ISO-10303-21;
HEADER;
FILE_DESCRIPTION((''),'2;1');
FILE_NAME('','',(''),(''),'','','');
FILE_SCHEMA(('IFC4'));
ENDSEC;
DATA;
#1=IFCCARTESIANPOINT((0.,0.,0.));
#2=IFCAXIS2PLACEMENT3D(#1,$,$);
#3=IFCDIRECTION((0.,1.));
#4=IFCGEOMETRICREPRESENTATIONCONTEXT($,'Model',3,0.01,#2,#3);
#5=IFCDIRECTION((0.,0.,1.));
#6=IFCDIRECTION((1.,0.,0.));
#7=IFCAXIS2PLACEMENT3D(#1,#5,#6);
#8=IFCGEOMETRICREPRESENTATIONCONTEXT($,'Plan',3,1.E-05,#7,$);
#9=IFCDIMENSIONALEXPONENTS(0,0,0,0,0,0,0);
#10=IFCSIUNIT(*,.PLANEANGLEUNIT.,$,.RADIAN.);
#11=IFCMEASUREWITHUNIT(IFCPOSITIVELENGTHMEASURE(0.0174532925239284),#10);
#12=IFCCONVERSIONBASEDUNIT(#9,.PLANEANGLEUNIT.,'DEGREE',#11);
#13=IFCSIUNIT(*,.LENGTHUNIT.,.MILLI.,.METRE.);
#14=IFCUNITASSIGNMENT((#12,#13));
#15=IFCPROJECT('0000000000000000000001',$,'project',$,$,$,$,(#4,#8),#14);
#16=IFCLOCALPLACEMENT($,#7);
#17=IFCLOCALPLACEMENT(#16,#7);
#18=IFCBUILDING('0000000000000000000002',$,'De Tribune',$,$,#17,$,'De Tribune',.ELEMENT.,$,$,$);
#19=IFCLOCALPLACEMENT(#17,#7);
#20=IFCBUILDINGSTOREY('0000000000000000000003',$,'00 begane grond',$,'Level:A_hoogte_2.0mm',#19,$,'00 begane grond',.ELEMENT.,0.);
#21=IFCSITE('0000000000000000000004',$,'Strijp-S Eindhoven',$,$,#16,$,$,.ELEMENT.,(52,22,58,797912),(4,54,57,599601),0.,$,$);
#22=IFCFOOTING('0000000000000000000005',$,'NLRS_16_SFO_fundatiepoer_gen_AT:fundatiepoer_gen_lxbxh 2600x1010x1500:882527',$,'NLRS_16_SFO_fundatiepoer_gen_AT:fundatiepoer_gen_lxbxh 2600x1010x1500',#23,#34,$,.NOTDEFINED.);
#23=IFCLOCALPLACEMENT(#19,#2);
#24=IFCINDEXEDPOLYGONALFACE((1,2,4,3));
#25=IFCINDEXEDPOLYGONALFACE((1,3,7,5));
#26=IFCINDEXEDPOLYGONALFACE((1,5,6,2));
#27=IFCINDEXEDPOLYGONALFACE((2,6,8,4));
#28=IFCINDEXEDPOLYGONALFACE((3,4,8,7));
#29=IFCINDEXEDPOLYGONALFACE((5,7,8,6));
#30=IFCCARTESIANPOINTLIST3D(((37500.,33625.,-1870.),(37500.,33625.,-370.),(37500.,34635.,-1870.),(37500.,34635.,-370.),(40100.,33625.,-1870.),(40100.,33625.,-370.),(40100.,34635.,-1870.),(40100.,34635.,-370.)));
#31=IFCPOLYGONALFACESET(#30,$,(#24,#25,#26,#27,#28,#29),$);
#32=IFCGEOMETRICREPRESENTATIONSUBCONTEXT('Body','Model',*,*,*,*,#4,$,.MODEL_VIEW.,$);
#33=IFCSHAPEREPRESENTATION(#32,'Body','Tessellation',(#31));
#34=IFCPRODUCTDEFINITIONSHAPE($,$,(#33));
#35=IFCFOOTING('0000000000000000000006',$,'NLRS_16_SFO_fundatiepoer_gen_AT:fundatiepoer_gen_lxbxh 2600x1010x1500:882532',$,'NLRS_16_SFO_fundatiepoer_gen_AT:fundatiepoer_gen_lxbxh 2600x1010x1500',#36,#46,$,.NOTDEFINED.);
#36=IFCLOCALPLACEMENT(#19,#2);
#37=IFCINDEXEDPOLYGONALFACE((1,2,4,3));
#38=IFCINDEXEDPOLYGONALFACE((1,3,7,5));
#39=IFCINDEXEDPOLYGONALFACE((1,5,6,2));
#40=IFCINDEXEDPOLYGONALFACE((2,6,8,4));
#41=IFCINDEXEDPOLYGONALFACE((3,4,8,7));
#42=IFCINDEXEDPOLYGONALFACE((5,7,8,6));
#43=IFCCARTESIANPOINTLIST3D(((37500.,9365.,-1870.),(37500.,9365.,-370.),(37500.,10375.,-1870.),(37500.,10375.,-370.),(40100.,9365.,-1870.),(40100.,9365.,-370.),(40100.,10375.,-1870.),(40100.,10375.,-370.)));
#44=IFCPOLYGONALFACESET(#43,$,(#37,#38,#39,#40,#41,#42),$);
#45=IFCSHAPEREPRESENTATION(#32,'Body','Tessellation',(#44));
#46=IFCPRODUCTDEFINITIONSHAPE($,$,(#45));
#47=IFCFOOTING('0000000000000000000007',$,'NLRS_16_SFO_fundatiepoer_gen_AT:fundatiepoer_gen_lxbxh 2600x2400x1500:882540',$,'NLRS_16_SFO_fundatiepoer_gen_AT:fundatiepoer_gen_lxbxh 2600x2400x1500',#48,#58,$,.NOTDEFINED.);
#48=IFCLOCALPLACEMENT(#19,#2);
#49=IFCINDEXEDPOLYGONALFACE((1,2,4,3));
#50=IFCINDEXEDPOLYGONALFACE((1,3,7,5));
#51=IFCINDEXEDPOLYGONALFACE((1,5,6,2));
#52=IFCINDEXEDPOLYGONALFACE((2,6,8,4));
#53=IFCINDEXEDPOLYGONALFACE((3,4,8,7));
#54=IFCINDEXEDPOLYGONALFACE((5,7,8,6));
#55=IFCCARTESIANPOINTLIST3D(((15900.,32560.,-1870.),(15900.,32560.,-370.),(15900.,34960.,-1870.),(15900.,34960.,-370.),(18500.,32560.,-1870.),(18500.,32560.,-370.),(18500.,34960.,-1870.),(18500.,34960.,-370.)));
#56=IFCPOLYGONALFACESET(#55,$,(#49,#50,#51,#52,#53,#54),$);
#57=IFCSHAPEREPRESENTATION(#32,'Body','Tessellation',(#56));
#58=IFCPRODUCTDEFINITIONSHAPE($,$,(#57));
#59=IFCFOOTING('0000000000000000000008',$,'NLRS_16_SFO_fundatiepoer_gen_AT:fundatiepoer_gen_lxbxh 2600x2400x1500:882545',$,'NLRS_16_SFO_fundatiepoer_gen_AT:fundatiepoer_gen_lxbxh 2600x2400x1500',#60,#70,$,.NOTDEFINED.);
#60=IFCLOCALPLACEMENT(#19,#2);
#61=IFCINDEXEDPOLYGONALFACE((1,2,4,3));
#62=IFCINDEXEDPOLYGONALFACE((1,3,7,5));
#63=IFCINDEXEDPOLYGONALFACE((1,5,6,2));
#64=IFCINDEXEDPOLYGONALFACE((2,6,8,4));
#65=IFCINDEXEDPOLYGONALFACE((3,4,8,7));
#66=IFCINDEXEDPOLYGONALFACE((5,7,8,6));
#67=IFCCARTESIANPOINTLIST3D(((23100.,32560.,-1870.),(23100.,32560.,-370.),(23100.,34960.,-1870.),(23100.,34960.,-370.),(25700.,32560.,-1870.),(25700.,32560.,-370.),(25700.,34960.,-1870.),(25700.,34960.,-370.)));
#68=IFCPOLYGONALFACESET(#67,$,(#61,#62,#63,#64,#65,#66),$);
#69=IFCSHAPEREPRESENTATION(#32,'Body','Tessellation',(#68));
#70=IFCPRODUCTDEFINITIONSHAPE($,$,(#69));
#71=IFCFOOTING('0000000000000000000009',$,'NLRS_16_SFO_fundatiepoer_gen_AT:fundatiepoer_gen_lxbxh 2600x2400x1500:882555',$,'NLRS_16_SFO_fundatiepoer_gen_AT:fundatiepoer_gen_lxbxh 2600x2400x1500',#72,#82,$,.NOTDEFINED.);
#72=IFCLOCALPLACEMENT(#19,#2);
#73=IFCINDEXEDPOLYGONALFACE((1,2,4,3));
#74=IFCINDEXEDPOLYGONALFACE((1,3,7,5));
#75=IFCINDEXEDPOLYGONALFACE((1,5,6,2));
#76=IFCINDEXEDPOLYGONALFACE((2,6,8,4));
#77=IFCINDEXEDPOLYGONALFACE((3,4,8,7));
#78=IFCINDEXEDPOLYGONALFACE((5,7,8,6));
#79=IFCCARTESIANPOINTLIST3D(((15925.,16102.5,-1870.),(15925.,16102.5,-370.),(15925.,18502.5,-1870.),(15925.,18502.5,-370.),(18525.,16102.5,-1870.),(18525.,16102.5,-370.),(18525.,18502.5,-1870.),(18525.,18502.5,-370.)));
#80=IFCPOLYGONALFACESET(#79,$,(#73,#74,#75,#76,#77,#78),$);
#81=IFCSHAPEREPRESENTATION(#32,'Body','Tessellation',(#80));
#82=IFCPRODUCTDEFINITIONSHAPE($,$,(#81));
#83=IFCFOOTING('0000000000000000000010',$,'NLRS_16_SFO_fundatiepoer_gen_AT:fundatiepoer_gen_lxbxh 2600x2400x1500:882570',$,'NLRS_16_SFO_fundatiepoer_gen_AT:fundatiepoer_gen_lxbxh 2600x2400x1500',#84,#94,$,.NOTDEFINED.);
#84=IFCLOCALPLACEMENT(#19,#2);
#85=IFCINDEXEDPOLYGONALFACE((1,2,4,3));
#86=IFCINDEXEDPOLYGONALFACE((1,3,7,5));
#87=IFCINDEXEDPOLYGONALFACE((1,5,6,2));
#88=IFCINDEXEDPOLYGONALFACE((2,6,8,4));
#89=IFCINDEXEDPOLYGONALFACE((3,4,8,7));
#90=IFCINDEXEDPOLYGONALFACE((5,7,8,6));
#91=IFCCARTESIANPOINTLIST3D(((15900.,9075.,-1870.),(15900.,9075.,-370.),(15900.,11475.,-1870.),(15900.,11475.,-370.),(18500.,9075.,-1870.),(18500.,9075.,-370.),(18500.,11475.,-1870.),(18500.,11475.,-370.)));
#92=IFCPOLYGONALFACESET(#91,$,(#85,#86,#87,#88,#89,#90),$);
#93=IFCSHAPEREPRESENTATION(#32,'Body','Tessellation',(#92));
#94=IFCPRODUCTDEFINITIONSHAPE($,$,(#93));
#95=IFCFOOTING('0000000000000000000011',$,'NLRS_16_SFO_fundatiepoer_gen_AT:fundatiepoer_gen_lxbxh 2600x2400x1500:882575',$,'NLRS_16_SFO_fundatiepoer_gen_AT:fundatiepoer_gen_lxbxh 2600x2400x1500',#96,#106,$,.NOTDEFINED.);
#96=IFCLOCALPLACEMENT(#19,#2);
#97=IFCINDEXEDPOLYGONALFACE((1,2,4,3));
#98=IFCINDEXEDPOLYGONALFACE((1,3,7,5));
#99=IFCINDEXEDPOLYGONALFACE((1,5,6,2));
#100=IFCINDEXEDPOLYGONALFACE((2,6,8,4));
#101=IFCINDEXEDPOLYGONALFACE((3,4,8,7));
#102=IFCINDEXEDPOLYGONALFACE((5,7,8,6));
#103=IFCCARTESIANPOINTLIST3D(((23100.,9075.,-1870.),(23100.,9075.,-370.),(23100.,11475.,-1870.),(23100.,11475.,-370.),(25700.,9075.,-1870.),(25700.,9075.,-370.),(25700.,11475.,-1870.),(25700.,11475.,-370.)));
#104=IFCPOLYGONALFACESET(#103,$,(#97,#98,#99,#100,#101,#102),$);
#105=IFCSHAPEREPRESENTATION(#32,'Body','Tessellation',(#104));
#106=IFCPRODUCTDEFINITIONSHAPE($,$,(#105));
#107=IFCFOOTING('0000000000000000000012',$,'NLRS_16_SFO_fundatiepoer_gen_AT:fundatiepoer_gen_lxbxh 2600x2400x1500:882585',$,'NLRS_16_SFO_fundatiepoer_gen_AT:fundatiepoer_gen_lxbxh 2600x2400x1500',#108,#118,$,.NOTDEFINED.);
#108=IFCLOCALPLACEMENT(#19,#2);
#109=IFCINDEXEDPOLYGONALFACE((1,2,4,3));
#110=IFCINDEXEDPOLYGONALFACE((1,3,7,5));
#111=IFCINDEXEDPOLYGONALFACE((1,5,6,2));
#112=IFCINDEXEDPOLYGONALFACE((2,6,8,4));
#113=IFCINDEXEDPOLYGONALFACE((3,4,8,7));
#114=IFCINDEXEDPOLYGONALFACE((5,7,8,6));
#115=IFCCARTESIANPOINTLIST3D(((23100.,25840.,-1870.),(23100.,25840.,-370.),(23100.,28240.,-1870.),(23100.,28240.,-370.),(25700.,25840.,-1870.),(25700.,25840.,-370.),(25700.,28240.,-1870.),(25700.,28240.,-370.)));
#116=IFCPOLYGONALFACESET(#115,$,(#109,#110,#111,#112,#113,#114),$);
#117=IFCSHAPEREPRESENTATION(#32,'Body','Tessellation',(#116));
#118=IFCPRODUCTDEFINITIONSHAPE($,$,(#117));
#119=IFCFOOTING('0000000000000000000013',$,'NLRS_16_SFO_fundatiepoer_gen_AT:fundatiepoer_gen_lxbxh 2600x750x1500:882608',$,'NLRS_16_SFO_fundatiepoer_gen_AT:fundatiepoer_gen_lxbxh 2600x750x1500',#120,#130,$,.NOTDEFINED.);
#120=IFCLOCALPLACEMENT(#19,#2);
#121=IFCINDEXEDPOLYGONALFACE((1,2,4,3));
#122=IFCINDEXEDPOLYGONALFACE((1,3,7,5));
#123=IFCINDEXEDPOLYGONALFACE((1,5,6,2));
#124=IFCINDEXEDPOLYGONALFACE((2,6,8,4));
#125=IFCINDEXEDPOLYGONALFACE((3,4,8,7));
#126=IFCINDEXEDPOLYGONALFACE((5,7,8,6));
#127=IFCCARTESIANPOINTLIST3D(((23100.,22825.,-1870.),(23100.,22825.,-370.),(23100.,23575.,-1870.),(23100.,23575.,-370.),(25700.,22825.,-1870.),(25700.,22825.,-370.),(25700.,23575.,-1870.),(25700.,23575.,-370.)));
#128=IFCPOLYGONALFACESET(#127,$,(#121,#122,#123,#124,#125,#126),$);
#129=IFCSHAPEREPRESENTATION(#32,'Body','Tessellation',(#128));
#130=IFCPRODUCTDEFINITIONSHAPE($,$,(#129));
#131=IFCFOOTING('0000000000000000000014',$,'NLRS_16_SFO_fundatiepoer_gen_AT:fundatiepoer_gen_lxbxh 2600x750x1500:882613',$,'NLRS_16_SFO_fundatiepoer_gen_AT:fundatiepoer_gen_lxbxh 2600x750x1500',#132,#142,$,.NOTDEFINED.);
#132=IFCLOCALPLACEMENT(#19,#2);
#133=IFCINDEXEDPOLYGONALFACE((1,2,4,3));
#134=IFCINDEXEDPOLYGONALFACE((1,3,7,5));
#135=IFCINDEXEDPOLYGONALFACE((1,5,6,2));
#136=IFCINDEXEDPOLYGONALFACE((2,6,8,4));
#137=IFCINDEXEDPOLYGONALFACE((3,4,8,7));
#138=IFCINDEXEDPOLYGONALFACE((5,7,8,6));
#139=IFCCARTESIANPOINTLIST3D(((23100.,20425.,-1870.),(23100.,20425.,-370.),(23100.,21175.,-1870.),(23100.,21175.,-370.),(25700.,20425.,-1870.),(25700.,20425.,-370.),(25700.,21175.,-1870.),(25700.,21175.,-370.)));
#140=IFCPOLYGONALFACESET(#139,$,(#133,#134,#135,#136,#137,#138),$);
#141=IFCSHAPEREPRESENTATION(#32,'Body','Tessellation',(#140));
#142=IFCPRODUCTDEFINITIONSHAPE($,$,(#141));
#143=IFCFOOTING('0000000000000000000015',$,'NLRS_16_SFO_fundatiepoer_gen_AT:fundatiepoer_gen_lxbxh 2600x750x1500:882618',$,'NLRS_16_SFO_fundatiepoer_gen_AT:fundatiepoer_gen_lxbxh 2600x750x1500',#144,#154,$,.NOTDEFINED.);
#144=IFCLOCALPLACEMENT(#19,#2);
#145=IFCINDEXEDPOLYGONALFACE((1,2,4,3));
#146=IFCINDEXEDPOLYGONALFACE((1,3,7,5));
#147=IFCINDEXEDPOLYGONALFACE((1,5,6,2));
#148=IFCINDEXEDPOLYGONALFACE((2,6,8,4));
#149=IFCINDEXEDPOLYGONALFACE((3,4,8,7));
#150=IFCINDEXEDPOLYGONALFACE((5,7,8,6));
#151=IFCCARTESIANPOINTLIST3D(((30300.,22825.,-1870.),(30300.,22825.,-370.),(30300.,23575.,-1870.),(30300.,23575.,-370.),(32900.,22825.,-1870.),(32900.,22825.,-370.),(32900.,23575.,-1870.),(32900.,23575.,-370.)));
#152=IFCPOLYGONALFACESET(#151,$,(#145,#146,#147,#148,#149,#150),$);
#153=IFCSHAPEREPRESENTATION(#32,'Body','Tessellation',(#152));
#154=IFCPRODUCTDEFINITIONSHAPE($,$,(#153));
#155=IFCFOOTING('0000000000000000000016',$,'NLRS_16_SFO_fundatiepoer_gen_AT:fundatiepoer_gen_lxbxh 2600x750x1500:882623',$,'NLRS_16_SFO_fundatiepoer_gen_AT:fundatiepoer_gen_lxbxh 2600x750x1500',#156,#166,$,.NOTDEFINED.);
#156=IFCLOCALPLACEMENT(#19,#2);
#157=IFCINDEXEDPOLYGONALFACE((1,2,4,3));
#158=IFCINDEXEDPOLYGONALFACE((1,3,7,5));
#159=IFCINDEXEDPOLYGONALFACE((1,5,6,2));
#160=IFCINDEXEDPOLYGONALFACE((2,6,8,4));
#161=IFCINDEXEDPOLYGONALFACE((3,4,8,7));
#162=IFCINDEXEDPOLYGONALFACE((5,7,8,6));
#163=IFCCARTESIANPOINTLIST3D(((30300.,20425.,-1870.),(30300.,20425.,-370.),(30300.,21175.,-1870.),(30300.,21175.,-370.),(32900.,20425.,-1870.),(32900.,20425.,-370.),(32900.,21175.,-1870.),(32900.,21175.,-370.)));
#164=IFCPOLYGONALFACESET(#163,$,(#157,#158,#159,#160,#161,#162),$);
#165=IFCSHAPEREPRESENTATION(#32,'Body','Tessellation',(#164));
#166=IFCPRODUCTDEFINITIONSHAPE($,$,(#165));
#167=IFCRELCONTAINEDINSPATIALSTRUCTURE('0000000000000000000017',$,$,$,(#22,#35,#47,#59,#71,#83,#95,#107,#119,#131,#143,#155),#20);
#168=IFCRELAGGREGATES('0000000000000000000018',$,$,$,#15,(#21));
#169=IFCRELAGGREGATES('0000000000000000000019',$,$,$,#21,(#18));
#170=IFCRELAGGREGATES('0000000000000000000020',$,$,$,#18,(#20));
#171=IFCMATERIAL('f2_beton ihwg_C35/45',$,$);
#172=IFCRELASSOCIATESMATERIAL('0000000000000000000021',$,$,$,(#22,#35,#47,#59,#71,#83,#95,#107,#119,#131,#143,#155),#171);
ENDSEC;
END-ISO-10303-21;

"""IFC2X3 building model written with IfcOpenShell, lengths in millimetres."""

from ifc_helpers import new_model, entity, si_unit, converted_unit, direction, frame, frame_2d, origin, origin_with_axes, place, context, subcontext, project, spatial, rectangle, extrude, source, transform, mapped, material, element, save


model = new_model("IFC2X3")

# Units and contexts
model_context = context("Model", 3, precision=0.01, world=origin(), true_north=direction((0.0, 1.0)))
plan_context = context("Plan", 3, precision=1e-05, world=origin_with_axes())
body_context = subcontext(model_context, "Body", "Model", "MODEL_VIEW")
ifc_project = project(units=[converted_unit("PLANEANGLEUNIT", "DEGREE", entity("IfcPositiveLengthMeasure", 0.0174532925239284), si_unit("PLANEANGLEUNIT", "RADIAN"), dimensions=[0, 0, 0, 0, 0, 0, 0]), si_unit("LENGTHUNIT", "METRE", prefix="MILLI")], contexts=[model_context, plan_context])

# Site, building, storey
site_placement = place(None, origin_with_axes())
site = spatial("IfcSite", under=ifc_project, at=site_placement, Name="Strijp-S Eindhoven", CompositionType="ELEMENT", RefLatitude=(52, 22, 58, 797912), RefLongitude=(4, 54, 57, 599601), RefElevation=0.0)
building_placement = place(site_placement, origin_with_axes())
building = spatial("IfcBuilding", under=site, at=building_placement, Name="De Tribune", LongName="De Tribune", CompositionType="ELEMENT")
storey_placement = place(building_placement, origin_with_axes())
storey = spatial("IfcBuildingStorey", under=building, at=storey_placement, Name="00 begane grond", ObjectType="Level:A_hoogte_2.0mm", LongName="00 begane grond", CompositionType="ELEMENT", Elevation=0.0)

# Footings
ifc_material_1 = material(Name="f2_beton ihwg_C35/45")
shared_shape_1 = source(origin(), body_context, "Body", "SweptSolid", [
    extrude(rectangle(XDim=1010.0, YDim=2600.0, at=frame_2d((0.0, 0.0), x_axis=(1.0, 0.0))), frame((38800.0, 34130.0, -1870.0), z_axis=(0.0, 0.0, 1.0), x_axis=(0.0, 1.0, 0.0)), (0.0, 0.0, 1.0), 1500.0),
])
footing_1_placement = place(storey_placement, origin_with_axes())
element("IfcFooting", 1, at=footing_1_placement, inside=storey, material=ifc_material_1, Name="NLRS_16_SFO_fundatiepoer_gen_AT:fundatiepoer_gen_lxbxh 2600x1010x1500:882527", ObjectType="NLRS_16_SFO_fundatiepoer_gen_AT:fundatiepoer_gen_lxbxh 2600x1010x1500", PredefinedType="NOTDEFINED", context=body_context, shape_type="MappedRepresentation", body=[
    mapped(shared_shape_1, transform((0.0, 0.0, 0.0), scale=1.0)),
])
shared_shape_2 = source(origin(), body_context, "Body", "SweptSolid", [
    extrude(rectangle(XDim=1010.0, YDim=2600.0, at=frame_2d((0.0, 0.0), x_axis=(1.0, 0.0))), frame((38800.0, 9870.0, -1870.0), z_axis=(0.0, 0.0, 1.0), x_axis=(0.0, -1.0, 0.0)), (0.0, 0.0, 1.0), 1500.0),
])
footing_2_placement = place(storey_placement, origin_with_axes())
element("IfcFooting", 2, at=footing_2_placement, inside=storey, material=ifc_material_1, Name="NLRS_16_SFO_fundatiepoer_gen_AT:fundatiepoer_gen_lxbxh 2600x1010x1500:882532", ObjectType="NLRS_16_SFO_fundatiepoer_gen_AT:fundatiepoer_gen_lxbxh 2600x1010x1500", PredefinedType="NOTDEFINED", context=body_context, shape_type="MappedRepresentation", body=[
    mapped(shared_shape_2, transform((0.0, 0.0, 0.0), scale=1.0)),
])
shared_shape_3 = source(origin(), body_context, "Body", "SweptSolid", [
    extrude(rectangle(XDim=2400.0, YDim=2600.0, at=frame_2d((0.0, 0.0), x_axis=(1.0, 0.0))), frame((17200.0, 33760.0, -1870.0), z_axis=(0.0, 0.0, 1.0), x_axis=(0.0, -1.0, 0.0)), (0.0, 0.0, 1.0), 1500.0),
])
footing_3_placement = place(storey_placement, origin_with_axes())
element("IfcFooting", 3, at=footing_3_placement, inside=storey, material=ifc_material_1, Name="NLRS_16_SFO_fundatiepoer_gen_AT:fundatiepoer_gen_lxbxh 2600x2400x1500:882540", ObjectType="NLRS_16_SFO_fundatiepoer_gen_AT:fundatiepoer_gen_lxbxh 2600x2400x1500", PredefinedType="NOTDEFINED", context=body_context, shape_type="MappedRepresentation", body=[
    mapped(shared_shape_3, transform((0.0, 0.0, 0.0), scale=1.0)),
])
shared_shape_4 = source(origin(), body_context, "Body", "SweptSolid", [
    extrude(rectangle(XDim=2400.0, YDim=2600.0, at=frame_2d((0.0, 0.0), x_axis=(1.0, 0.0))), frame((24400.0, 33760.0, -1870.0), z_axis=(0.0, 0.0, 1.0), x_axis=(0.0, -1.0, 0.0)), (0.0, 0.0, 1.0), 1500.0),
])
footing_4_placement = place(storey_placement, origin_with_axes())
element("IfcFooting", 4, at=footing_4_placement, inside=storey, material=ifc_material_1, Name="NLRS_16_SFO_fundatiepoer_gen_AT:fundatiepoer_gen_lxbxh 2600x2400x1500:882545", ObjectType="NLRS_16_SFO_fundatiepoer_gen_AT:fundatiepoer_gen_lxbxh 2600x2400x1500", PredefinedType="NOTDEFINED", context=body_context, shape_type="MappedRepresentation", body=[
    mapped(shared_shape_4, transform((0.0, 0.0, 0.0), scale=1.0)),
])
shared_shape_5 = source(origin(), body_context, "Body", "SweptSolid", [
    extrude(rectangle(XDim=2400.0, YDim=2600.0, at=frame_2d((0.0, 0.0), x_axis=(1.0, 0.0))), frame((17225.0, 17302.5, -1870.0), z_axis=(0.0, 0.0, 1.0), x_axis=(0.0, -1.0, 0.0)), (0.0, 0.0, 1.0), 1500.0),
])
footing_5_placement = place(storey_placement, origin_with_axes())
element("IfcFooting", 5, at=footing_5_placement, inside=storey, material=ifc_material_1, Name="NLRS_16_SFO_fundatiepoer_gen_AT:fundatiepoer_gen_lxbxh 2600x2400x1500:882555", ObjectType="NLRS_16_SFO_fundatiepoer_gen_AT:fundatiepoer_gen_lxbxh 2600x2400x1500", PredefinedType="NOTDEFINED", context=body_context, shape_type="MappedRepresentation", body=[
    mapped(shared_shape_5, transform((0.0, 0.0, 0.0), scale=1.0)),
])
shared_shape_6 = source(origin(), body_context, "Body", "SweptSolid", [
    extrude(rectangle(XDim=2600.0, YDim=2400.0, at=frame_2d((0.0, 0.0), x_axis=(1.0, 0.0))), frame((17200.0, 10275.0, -1870.0)), (0.0, 0.0, 1.0), 1500.0),
])
footing_6_placement = place(storey_placement, origin_with_axes())
element("IfcFooting", 6, at=footing_6_placement, inside=storey, material=ifc_material_1, Name="NLRS_16_SFO_fundatiepoer_gen_AT:fundatiepoer_gen_lxbxh 2600x2400x1500:882570", ObjectType="NLRS_16_SFO_fundatiepoer_gen_AT:fundatiepoer_gen_lxbxh 2600x2400x1500", PredefinedType="NOTDEFINED", context=body_context, shape_type="MappedRepresentation", body=[
    mapped(shared_shape_6, transform((0.0, 0.0, 0.0), scale=1.0)),
])
shared_shape_7 = source(origin(), body_context, "Body", "SweptSolid", [
    extrude(rectangle(XDim=2600.0, YDim=2400.0, at=frame_2d((0.0, 0.0), x_axis=(1.0, 0.0))), frame((24400.0, 10275.0, -1870.0)), (0.0, 0.0, 1.0), 1500.0),
])
footing_7_placement = place(storey_placement, origin_with_axes())
element("IfcFooting", 7, at=footing_7_placement, inside=storey, material=ifc_material_1, Name="NLRS_16_SFO_fundatiepoer_gen_AT:fundatiepoer_gen_lxbxh 2600x2400x1500:882575", ObjectType="NLRS_16_SFO_fundatiepoer_gen_AT:fundatiepoer_gen_lxbxh 2600x2400x1500", PredefinedType="NOTDEFINED", context=body_context, shape_type="MappedRepresentation", body=[
    mapped(shared_shape_7, transform((0.0, 0.0, 0.0), scale=1.0)),
])
shared_shape_8 = source(origin(), body_context, "Body", "SweptSolid", [
    extrude(rectangle(XDim=2600.0, YDim=2400.0, at=frame_2d((0.0, 0.0), x_axis=(1.0, 0.0))), frame((24400.0, 27040.0, -1870.0)), (0.0, 0.0, 1.0), 1500.0),
])
footing_8_placement = place(storey_placement, origin_with_axes())
element("IfcFooting", 8, at=footing_8_placement, inside=storey, material=ifc_material_1, Name="NLRS_16_SFO_fundatiepoer_gen_AT:fundatiepoer_gen_lxbxh 2600x2400x1500:882585", ObjectType="NLRS_16_SFO_fundatiepoer_gen_AT:fundatiepoer_gen_lxbxh 2600x2400x1500", PredefinedType="NOTDEFINED", context=body_context, shape_type="MappedRepresentation", body=[
    mapped(shared_shape_8, transform((0.0, 0.0, 0.0), scale=1.0)),
])
shared_shape_9 = source(origin(), body_context, "Body", "SweptSolid", [
    extrude(rectangle(XDim=750.0, YDim=2600.0, at=frame_2d((0.0, 0.0), x_axis=(1.0, 0.0))), frame((24400.0, 23200.0, -1870.0), z_axis=(0.0, 0.0, 1.0), x_axis=(0.0, -1.0, 0.0)), (0.0, 0.0, 1.0), 1500.0),
])
footing_9_placement = place(storey_placement, origin_with_axes())
element("IfcFooting", 9, at=footing_9_placement, inside=storey, material=ifc_material_1, Name="NLRS_16_SFO_fundatiepoer_gen_AT:fundatiepoer_gen_lxbxh 2600x750x1500:882608", ObjectType="NLRS_16_SFO_fundatiepoer_gen_AT:fundatiepoer_gen_lxbxh 2600x750x1500", PredefinedType="NOTDEFINED", context=body_context, shape_type="MappedRepresentation", body=[
    mapped(shared_shape_9, transform((0.0, 0.0, 0.0), scale=1.0)),
])
shared_shape_10 = source(origin(), body_context, "Body", "SweptSolid", [
    extrude(rectangle(XDim=750.0, YDim=2600.0, at=frame_2d((0.0, 0.0), x_axis=(1.0, 0.0))), frame((24400.0, 20800.0, -1870.0), z_axis=(0.0, 0.0, 1.0), x_axis=(0.0, -1.0, 0.0)), (0.0, 0.0, 1.0), 1500.0),
])
footing_10_placement = place(storey_placement, origin_with_axes())
element("IfcFooting", 10, at=footing_10_placement, inside=storey, material=ifc_material_1, Name="NLRS_16_SFO_fundatiepoer_gen_AT:fundatiepoer_gen_lxbxh 2600x750x1500:882613", ObjectType="NLRS_16_SFO_fundatiepoer_gen_AT:fundatiepoer_gen_lxbxh 2600x750x1500", PredefinedType="NOTDEFINED", context=body_context, shape_type="MappedRepresentation", body=[
    mapped(shared_shape_10, transform((0.0, 0.0, 0.0), scale=1.0)),
])
shared_shape_11 = source(origin(), body_context, "Body", "SweptSolid", [
    extrude(rectangle(XDim=750.0, YDim=2600.0, at=frame_2d((0.0, 0.0), x_axis=(1.0, 0.0))), frame((31600.0, 23200.0, -1870.0), z_axis=(0.0, 0.0, 1.0), x_axis=(0.0, -1.0, 0.0)), (0.0, 0.0, 1.0), 1500.0),
])
footing_11_placement = place(storey_placement, origin_with_axes())
element("IfcFooting", 11, at=footing_11_placement, inside=storey, material=ifc_material_1, Name="NLRS_16_SFO_fundatiepoer_gen_AT:fundatiepoer_gen_lxbxh 2600x750x1500:882618", ObjectType="NLRS_16_SFO_fundatiepoer_gen_AT:fundatiepoer_gen_lxbxh 2600x750x1500", PredefinedType="NOTDEFINED", context=body_context, shape_type="MappedRepresentation", body=[
    mapped(shared_shape_11, transform((0.0, 0.0, 0.0), scale=1.0)),
])
shared_shape_12 = source(origin(), body_context, "Body", "SweptSolid", [
    extrude(rectangle(XDim=750.0, YDim=2600.0, at=frame_2d((0.0, 0.0), x_axis=(1.0, 0.0))), frame((31600.0, 20800.0, -1870.0), z_axis=(0.0, 0.0, 1.0), x_axis=(0.0, -1.0, 0.0)), (0.0, 0.0, 1.0), 1500.0),
])
footing_12_placement = place(storey_placement, origin_with_axes())
element("IfcFooting", 12, at=footing_12_placement, inside=storey, material=ifc_material_1, Name="NLRS_16_SFO_fundatiepoer_gen_AT:fundatiepoer_gen_lxbxh 2600x750x1500:882623", ObjectType="NLRS_16_SFO_fundatiepoer_gen_AT:fundatiepoer_gen_lxbxh 2600x750x1500", PredefinedType="NOTDEFINED", context=body_context, shape_type="MappedRepresentation", body=[
    mapped(shared_shape_12, transform((0.0, 0.0, 0.0), scale=1.0)),
])

save(model, "model.ifc")
